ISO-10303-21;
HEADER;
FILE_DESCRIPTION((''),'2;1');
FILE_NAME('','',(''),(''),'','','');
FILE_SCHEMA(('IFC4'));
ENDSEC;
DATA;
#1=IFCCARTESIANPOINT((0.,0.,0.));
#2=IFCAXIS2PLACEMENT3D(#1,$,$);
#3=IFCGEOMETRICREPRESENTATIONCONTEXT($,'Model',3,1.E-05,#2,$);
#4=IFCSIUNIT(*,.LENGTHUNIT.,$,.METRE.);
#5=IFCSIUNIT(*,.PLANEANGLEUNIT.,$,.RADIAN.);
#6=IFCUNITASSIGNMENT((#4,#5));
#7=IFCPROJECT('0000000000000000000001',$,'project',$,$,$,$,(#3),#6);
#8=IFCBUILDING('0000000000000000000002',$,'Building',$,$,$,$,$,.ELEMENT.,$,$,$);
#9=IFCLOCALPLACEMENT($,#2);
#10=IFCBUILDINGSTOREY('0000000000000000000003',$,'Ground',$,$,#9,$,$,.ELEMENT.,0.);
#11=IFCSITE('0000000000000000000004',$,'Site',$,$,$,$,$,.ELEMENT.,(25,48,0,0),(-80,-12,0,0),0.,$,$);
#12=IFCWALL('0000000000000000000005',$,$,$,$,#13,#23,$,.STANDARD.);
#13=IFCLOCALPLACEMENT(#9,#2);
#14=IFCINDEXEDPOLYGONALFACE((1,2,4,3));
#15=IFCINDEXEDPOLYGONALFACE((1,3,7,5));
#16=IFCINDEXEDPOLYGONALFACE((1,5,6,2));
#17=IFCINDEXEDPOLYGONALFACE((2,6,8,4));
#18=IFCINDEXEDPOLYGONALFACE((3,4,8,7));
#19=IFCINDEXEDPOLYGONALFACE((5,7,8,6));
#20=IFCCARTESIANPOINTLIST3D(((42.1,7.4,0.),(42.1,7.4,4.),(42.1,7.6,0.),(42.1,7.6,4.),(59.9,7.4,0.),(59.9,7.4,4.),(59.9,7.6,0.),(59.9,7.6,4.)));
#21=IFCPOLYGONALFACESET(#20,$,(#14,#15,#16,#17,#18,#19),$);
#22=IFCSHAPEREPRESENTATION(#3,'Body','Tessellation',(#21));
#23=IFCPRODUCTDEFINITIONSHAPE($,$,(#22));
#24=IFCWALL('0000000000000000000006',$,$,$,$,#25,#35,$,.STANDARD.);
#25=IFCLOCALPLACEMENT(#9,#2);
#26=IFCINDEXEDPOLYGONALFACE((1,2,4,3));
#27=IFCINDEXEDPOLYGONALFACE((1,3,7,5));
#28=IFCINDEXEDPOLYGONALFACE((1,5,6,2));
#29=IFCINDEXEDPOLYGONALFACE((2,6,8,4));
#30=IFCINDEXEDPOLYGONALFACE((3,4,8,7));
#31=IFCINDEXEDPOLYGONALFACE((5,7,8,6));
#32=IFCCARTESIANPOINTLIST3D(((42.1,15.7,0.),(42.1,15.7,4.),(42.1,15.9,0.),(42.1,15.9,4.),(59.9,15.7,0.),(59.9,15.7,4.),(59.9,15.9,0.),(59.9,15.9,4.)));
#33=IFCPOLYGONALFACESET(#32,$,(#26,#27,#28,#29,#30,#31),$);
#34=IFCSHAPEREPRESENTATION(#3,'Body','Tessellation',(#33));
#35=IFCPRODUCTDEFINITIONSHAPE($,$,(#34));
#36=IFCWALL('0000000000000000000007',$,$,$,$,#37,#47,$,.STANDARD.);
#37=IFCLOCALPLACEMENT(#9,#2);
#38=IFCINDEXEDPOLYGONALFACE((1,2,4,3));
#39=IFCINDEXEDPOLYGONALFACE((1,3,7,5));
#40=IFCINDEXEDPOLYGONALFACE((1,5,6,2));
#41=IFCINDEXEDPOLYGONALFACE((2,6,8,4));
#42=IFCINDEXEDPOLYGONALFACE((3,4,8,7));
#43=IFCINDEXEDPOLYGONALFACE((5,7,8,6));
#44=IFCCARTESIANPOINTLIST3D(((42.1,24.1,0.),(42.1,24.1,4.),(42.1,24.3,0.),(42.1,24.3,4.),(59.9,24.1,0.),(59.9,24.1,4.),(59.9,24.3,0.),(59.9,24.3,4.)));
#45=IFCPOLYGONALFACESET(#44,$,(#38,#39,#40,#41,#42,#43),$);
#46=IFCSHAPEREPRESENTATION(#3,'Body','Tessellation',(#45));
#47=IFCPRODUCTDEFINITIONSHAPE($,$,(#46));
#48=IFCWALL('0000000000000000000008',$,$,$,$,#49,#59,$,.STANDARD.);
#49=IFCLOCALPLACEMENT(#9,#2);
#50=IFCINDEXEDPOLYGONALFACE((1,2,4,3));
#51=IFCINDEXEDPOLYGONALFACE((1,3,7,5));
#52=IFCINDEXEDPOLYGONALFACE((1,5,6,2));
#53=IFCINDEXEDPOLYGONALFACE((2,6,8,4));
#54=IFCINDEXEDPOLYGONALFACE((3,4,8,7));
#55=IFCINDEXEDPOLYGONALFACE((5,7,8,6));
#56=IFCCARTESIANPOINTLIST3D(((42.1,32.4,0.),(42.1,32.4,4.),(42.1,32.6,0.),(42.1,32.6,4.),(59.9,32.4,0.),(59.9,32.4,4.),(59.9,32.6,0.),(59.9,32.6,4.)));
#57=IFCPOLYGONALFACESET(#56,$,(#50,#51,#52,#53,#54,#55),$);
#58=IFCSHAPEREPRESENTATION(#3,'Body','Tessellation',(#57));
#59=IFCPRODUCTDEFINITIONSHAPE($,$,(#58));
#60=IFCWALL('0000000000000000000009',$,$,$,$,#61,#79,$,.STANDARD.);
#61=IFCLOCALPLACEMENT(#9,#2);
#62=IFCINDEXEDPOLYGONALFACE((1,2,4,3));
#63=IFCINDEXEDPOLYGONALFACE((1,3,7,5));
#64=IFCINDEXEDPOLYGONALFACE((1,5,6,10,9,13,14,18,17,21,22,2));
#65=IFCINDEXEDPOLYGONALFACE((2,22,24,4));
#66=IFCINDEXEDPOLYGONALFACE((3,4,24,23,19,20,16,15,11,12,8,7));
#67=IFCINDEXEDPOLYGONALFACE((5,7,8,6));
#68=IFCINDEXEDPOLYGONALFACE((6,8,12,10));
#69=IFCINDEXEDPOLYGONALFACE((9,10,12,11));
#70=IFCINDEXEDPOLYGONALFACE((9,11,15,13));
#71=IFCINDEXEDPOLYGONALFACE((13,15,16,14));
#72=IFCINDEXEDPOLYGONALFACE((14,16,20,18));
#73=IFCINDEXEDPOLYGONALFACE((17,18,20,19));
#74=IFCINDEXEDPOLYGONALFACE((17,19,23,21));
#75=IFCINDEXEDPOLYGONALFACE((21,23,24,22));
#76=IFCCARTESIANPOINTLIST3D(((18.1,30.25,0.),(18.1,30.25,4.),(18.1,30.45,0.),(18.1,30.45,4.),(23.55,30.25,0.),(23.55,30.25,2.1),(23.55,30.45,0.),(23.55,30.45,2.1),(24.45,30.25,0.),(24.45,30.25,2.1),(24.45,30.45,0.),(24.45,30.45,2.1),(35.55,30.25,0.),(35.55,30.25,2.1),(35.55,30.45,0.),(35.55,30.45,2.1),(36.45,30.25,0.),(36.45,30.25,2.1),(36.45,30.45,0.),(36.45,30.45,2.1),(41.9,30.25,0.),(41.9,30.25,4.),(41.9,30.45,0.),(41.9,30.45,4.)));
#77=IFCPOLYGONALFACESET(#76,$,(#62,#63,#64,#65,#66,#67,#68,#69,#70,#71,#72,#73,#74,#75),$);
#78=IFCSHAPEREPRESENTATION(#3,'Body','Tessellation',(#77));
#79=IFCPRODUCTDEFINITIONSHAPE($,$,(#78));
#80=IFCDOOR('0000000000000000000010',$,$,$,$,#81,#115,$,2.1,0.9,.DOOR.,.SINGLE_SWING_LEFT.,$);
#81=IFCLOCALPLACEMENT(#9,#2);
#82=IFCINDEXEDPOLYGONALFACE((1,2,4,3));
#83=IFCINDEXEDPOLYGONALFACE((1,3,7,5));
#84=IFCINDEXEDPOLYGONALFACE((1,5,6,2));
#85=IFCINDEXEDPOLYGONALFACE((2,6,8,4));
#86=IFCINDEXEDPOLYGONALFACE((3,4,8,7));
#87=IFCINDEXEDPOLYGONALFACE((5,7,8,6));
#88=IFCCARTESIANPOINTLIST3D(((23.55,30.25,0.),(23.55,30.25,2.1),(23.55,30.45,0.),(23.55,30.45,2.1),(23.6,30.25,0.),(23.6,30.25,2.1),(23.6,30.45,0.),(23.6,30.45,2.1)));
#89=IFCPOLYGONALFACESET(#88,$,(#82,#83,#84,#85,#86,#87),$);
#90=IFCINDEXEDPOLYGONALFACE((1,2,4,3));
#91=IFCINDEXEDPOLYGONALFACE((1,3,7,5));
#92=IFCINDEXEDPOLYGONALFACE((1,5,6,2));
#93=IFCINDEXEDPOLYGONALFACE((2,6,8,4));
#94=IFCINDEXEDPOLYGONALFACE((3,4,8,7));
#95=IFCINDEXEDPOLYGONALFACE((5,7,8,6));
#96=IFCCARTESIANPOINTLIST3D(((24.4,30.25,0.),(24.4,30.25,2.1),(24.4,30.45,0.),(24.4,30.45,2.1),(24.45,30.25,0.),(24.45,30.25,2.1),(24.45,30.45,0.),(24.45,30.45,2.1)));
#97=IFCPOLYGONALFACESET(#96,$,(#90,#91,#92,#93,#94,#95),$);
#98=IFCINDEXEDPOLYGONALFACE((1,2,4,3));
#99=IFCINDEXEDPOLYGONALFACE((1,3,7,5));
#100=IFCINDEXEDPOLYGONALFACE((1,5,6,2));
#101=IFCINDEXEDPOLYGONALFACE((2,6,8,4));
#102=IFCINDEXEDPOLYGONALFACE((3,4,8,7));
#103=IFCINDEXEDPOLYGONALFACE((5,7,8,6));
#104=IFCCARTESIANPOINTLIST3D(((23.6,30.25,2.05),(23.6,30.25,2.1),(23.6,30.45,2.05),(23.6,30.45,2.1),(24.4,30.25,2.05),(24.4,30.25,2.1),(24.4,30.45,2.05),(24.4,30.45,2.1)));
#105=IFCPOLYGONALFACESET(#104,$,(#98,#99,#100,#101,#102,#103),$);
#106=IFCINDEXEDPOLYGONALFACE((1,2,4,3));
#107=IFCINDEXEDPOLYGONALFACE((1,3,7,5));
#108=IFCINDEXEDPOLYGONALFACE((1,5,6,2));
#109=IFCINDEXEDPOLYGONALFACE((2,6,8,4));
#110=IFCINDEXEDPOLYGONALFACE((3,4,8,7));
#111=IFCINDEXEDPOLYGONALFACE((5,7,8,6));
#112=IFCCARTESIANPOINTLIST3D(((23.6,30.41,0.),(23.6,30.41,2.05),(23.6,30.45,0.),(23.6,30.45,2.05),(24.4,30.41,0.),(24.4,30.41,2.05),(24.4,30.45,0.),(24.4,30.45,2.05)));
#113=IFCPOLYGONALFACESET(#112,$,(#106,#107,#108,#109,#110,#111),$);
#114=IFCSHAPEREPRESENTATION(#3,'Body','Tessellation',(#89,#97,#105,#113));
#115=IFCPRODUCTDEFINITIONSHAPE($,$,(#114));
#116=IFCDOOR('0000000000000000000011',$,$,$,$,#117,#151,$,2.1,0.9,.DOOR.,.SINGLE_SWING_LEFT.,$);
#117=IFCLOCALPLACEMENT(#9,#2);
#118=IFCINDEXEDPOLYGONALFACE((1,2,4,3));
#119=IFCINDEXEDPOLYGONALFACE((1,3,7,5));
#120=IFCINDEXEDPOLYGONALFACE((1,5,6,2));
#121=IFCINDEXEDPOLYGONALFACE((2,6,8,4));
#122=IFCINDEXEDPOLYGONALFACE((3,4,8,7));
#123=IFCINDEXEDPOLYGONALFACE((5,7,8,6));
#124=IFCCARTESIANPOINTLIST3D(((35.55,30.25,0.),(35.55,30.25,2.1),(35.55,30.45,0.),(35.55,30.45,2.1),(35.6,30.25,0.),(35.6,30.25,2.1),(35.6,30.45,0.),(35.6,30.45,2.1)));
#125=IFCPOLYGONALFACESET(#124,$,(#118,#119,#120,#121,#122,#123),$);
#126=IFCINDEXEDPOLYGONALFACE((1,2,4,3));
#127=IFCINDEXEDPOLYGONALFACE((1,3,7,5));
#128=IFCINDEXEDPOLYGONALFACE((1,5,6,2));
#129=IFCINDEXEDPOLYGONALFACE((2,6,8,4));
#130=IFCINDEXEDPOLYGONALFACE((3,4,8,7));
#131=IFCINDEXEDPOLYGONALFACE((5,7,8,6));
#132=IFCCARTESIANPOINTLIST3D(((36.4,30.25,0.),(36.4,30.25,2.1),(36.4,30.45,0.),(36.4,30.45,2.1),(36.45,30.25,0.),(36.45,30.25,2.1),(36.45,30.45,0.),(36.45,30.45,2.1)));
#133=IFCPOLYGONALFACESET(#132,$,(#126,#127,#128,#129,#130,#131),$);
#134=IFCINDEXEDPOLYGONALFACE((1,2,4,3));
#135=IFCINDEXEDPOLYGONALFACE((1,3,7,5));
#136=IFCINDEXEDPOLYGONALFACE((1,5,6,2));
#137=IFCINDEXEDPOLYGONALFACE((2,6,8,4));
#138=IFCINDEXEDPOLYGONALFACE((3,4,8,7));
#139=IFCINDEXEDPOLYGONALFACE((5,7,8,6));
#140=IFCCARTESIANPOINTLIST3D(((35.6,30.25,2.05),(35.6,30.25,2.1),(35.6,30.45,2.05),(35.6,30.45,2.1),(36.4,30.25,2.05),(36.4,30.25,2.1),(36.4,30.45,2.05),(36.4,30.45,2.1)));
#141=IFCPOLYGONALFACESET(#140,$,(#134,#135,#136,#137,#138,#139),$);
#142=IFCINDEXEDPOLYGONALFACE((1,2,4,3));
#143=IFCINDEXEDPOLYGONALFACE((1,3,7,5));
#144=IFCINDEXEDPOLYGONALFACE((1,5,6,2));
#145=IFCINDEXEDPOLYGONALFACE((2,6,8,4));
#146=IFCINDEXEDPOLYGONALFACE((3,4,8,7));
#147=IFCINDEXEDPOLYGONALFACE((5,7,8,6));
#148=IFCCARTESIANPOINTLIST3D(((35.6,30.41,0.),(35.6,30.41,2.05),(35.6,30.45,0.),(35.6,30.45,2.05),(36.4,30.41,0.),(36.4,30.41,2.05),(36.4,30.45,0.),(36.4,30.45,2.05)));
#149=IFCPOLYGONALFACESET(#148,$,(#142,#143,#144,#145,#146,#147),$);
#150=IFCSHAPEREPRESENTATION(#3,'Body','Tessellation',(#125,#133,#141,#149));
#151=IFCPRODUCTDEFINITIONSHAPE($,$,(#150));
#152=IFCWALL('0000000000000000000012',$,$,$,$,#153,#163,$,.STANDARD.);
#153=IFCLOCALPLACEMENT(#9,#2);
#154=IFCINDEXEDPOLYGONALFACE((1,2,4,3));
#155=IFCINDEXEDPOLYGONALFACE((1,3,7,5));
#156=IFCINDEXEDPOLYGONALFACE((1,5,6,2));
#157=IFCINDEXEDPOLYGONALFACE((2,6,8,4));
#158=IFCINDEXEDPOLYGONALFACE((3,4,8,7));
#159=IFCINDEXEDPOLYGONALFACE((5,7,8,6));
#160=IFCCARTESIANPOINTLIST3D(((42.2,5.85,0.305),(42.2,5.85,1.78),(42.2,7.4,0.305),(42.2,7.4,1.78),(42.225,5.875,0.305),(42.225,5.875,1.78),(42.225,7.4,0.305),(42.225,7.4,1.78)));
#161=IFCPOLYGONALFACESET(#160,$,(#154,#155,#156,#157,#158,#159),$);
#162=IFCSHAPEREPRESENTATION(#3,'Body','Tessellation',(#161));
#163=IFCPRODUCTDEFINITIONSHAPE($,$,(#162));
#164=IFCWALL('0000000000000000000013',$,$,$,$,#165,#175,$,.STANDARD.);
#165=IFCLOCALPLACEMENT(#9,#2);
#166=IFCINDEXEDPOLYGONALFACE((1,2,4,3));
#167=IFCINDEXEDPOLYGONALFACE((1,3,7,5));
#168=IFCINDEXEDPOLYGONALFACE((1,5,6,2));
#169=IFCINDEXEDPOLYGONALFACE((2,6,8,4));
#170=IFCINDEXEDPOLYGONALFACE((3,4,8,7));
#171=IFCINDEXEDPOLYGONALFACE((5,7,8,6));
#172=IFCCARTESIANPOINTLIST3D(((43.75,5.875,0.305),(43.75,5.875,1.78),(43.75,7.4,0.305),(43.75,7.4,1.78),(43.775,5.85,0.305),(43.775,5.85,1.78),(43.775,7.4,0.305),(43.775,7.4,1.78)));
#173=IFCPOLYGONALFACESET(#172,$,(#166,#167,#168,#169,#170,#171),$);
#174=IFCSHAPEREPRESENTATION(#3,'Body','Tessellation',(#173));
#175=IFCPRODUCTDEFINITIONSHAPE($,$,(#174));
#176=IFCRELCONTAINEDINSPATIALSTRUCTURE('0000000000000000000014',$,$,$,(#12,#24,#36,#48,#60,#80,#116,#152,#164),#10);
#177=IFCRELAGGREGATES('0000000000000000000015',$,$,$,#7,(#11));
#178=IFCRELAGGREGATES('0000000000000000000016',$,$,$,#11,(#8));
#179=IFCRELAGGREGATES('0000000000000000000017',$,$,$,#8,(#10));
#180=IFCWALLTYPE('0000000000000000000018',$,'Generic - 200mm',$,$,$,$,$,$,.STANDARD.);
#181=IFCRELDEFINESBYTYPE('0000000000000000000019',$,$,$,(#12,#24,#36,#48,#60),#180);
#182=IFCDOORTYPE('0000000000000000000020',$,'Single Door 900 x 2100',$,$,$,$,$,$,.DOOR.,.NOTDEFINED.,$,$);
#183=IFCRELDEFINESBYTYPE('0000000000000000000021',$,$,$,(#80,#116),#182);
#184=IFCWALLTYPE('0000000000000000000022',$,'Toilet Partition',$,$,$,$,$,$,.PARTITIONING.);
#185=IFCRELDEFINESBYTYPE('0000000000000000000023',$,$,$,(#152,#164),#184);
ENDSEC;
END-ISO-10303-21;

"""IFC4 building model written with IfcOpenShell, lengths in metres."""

from ifc_helpers import new_model, si_unit, frame, frame_2d, origin, origin_with_axes, origin_2d, place, context, project, spatial, polyline, rectangle, outline, extrude, type_object, element, fill, save


model = new_model("IFC4")

# Units and contexts
model_context = context("Model", 3, precision=1e-05, world=origin())
ifc_project = project(units=[si_unit("LENGTHUNIT", "METRE"), si_unit("PLANEANGLEUNIT", "RADIAN")], contexts=[model_context])

# Site, building, storey
site = spatial("IfcSite", under=ifc_project, Name="Site", CompositionType="ELEMENT", RefLatitude=(25, 48, 0, 0), RefLongitude=(-80, -12, 0, 0), RefElevation=0.0)
building = spatial("IfcBuilding", under=site, Name="Building", CompositionType="ELEMENT")
storey_placement = place(None, origin())
storey = spatial("IfcBuildingStorey", under=building, at=storey_placement, Name="Ground", CompositionType="ELEMENT", Elevation=0.0)

# Shared definitions
wall_type_1 = type_object("IfcWallType", Name="Generic - 200mm", PredefinedType="STANDARD")
door_type = type_object("IfcDoorType", Name="Single Door 900 x 2100", OperationType="NOTDEFINED", PredefinedType="DOOR")

# Walls
for number, where, z_axis, x_axis in (
    (1, (42.0, 7.5, 0.0), (0.0, 0.0, 1.0), (1.0, 0.0, 0.0)),
    (2, (42.0, 15.8, 0.0), (0.0, 0.0, 1.0), (1.0, 0.0, 0.0)),
):
    element("IfcWall", number, at=place(None, frame(where, z_axis=z_axis, x_axis=x_axis)), inside=storey, type_object=wall_type_1, PredefinedType="STANDARD", context=model_context, shape_type="SweptSolid", body=[
        extrude(outline(polyline([(0.1, -0.1), (17.9, -0.1), (17.9, 0.1), (0.1, 0.1), (0.1, -0.1)])), origin(), (0.0, 0.0, 1.0), 4.0),
    ])
for number, where, z_axis, x_axis in (
    (3, (42.0, 24.2, 0.0), (0.0, 0.0, 1.0), (1.0, 0.0, 0.0)),
    (4, (42.0, 32.5, 0.0), (0.0, 0.0, 1.0), (1.0, 0.0, 0.0)),
):
    element("IfcWall", number, at=place(None, frame(where, z_axis=z_axis, x_axis=x_axis)), inside=storey, type_object=wall_type_1, PredefinedType="STANDARD", context=model_context, shape_type="SweptSolid", body=[
        extrude(outline(polyline([(0.1, -0.1), (17.9, -0.1), (17.9, 0.1), (0.1, 0.1), (0.1, -0.1)])), origin(), (0.0, 0.0, 1.0), 4.0),
    ])

# Wall, openings, doors
wall_1_placement = place(None, frame((18.0, 30.35, 0.0), z_axis=(0.0, 0.0, 1.0), x_axis=(1.0, 0.0, 0.0)))
wall_1 = element("IfcWall", 5, at=wall_1_placement, inside=storey, type_object=wall_type_1, PredefinedType="STANDARD", context=model_context, shape_type="SweptSolid", body=[
    extrude(outline(polyline([(0.1, -0.1), (23.9, -0.1), (23.9, 0.1), (0.1, 0.1), (0.1, -0.1)])), origin(), (0.0, 0.0, 1.0), 4.0),
])
opening_1_placement = place(wall_1_placement, frame((6.0, 0.0, 0.0), z_axis=(0.0, 0.0, 1.0), x_axis=(1.0, 0.0, 0.0)))
opening_1 = element("IfcOpeningElement", 6, at=opening_1_placement, cuts=wall_1, PredefinedType="OPENING", context=model_context, shape_type="SweptSolid", body=[
    extrude(rectangle(XDim=0.9, YDim=0.202, at=origin_2d()), origin(), (0.0, 0.0, 1.0), 2.1),
])
opening_2_placement = place(wall_1_placement, frame((18.0, 0.0, 0.0), z_axis=(0.0, 0.0, 1.0), x_axis=(1.0, 0.0, 0.0)))
opening_2 = element("IfcOpeningElement", 7, at=opening_2_placement, cuts=wall_1, PredefinedType="OPENING", context=model_context, shape_type="SweptSolid", body=[
    extrude(rectangle(XDim=0.9, YDim=0.202, at=origin_2d()), origin(), (0.0, 0.0, 1.0), 2.1),
])
door_1_placement = place(opening_1_placement, origin_with_axes())
door_1 = element("IfcDoor", 8, at=door_1_placement, inside=storey, type_object=door_type, OperationType="SINGLE_SWING_LEFT", OverallHeight=2.1, OverallWidth=0.9, PredefinedType="DOOR", context=model_context, shape_type="SweptSolid", body=[
    extrude(rectangle(XDim=0.05, YDim=0.2, at=frame_2d((-0.425, 0.0))), origin(), (0.0, 0.0, 1.0), 2.1),
    extrude(rectangle(XDim=0.05, YDim=0.2, at=frame_2d((0.425, 0.0))), origin(), (0.0, 0.0, 1.0), 2.1),
    extrude(rectangle(XDim=0.8, YDim=0.2, at=origin_2d()), frame((0.0, 0.0, 2.05)), (0.0, 0.0, 1.0), 0.05),
    extrude(rectangle(XDim=0.8, YDim=0.04, at=frame_2d((0.0, 0.08))), origin(), (0.0, 0.0, 1.0), 2.05),
])
fill(opening_1, door_1)
door_2_placement = place(opening_2_placement, origin_with_axes())
door_2 = element("IfcDoor", 9, at=door_2_placement, inside=storey, type_object=door_type, OperationType="SINGLE_SWING_LEFT", OverallHeight=2.1, OverallWidth=0.9, PredefinedType="DOOR", context=model_context, shape_type="SweptSolid", body=[
    extrude(rectangle(XDim=0.05, YDim=0.2, at=frame_2d((-0.425, 0.0))), origin(), (0.0, 0.0, 1.0), 2.1),
    extrude(rectangle(XDim=0.05, YDim=0.2, at=frame_2d((0.425, 0.0))), origin(), (0.0, 0.0, 1.0), 2.1),
    extrude(rectangle(XDim=0.8, YDim=0.2, at=origin_2d()), frame((0.0, 0.0, 2.05)), (0.0, 0.0, 1.0), 0.05),
    extrude(rectangle(XDim=0.8, YDim=0.04, at=frame_2d((0.0, 0.08))), origin(), (0.0, 0.0, 1.0), 2.05),
])
fill(opening_2, door_2)

# Walls
wall_type_2 = type_object("IfcWallType", Name="Toilet Partition", PredefinedType="PARTITIONING")
wall_2_placement = place(None, frame((42.2125, 7.4, 0.305), z_axis=(0.0, 0.0, 1.0), x_axis=(0.0, -1.0, 0.0)))
element("IfcWall", 10, at=wall_2_placement, inside=storey, type_object=wall_type_2, PredefinedType="STANDARD", context=model_context, shape_type="SweptSolid", body=[
    extrude(outline(polyline([(0.0, -0.0125), (1.55, -0.0125), (1.525, 0.0125), (0.0, 0.0125), (0.0, -0.0125)])), origin(), (0.0, 0.0, 1.0), 1.475),
])
wall_3_placement = place(None, frame((43.7625, 7.4, 0.305), z_axis=(0.0, 0.0, 1.0), x_axis=(0.0, -1.0, 0.0)))
element("IfcWall", 11, at=wall_3_placement, inside=storey, type_object=wall_type_2, PredefinedType="STANDARD", context=model_context, shape_type="SweptSolid", body=[
    extrude(outline(polyline([(0.0, -0.0125), (1.525, -0.0125), (1.55, 0.0125), (0.0, 0.0125), (0.0, -0.0125)])), origin(), (0.0, 0.0, 1.0), 1.475),
])

save(model, "model.ifc")
